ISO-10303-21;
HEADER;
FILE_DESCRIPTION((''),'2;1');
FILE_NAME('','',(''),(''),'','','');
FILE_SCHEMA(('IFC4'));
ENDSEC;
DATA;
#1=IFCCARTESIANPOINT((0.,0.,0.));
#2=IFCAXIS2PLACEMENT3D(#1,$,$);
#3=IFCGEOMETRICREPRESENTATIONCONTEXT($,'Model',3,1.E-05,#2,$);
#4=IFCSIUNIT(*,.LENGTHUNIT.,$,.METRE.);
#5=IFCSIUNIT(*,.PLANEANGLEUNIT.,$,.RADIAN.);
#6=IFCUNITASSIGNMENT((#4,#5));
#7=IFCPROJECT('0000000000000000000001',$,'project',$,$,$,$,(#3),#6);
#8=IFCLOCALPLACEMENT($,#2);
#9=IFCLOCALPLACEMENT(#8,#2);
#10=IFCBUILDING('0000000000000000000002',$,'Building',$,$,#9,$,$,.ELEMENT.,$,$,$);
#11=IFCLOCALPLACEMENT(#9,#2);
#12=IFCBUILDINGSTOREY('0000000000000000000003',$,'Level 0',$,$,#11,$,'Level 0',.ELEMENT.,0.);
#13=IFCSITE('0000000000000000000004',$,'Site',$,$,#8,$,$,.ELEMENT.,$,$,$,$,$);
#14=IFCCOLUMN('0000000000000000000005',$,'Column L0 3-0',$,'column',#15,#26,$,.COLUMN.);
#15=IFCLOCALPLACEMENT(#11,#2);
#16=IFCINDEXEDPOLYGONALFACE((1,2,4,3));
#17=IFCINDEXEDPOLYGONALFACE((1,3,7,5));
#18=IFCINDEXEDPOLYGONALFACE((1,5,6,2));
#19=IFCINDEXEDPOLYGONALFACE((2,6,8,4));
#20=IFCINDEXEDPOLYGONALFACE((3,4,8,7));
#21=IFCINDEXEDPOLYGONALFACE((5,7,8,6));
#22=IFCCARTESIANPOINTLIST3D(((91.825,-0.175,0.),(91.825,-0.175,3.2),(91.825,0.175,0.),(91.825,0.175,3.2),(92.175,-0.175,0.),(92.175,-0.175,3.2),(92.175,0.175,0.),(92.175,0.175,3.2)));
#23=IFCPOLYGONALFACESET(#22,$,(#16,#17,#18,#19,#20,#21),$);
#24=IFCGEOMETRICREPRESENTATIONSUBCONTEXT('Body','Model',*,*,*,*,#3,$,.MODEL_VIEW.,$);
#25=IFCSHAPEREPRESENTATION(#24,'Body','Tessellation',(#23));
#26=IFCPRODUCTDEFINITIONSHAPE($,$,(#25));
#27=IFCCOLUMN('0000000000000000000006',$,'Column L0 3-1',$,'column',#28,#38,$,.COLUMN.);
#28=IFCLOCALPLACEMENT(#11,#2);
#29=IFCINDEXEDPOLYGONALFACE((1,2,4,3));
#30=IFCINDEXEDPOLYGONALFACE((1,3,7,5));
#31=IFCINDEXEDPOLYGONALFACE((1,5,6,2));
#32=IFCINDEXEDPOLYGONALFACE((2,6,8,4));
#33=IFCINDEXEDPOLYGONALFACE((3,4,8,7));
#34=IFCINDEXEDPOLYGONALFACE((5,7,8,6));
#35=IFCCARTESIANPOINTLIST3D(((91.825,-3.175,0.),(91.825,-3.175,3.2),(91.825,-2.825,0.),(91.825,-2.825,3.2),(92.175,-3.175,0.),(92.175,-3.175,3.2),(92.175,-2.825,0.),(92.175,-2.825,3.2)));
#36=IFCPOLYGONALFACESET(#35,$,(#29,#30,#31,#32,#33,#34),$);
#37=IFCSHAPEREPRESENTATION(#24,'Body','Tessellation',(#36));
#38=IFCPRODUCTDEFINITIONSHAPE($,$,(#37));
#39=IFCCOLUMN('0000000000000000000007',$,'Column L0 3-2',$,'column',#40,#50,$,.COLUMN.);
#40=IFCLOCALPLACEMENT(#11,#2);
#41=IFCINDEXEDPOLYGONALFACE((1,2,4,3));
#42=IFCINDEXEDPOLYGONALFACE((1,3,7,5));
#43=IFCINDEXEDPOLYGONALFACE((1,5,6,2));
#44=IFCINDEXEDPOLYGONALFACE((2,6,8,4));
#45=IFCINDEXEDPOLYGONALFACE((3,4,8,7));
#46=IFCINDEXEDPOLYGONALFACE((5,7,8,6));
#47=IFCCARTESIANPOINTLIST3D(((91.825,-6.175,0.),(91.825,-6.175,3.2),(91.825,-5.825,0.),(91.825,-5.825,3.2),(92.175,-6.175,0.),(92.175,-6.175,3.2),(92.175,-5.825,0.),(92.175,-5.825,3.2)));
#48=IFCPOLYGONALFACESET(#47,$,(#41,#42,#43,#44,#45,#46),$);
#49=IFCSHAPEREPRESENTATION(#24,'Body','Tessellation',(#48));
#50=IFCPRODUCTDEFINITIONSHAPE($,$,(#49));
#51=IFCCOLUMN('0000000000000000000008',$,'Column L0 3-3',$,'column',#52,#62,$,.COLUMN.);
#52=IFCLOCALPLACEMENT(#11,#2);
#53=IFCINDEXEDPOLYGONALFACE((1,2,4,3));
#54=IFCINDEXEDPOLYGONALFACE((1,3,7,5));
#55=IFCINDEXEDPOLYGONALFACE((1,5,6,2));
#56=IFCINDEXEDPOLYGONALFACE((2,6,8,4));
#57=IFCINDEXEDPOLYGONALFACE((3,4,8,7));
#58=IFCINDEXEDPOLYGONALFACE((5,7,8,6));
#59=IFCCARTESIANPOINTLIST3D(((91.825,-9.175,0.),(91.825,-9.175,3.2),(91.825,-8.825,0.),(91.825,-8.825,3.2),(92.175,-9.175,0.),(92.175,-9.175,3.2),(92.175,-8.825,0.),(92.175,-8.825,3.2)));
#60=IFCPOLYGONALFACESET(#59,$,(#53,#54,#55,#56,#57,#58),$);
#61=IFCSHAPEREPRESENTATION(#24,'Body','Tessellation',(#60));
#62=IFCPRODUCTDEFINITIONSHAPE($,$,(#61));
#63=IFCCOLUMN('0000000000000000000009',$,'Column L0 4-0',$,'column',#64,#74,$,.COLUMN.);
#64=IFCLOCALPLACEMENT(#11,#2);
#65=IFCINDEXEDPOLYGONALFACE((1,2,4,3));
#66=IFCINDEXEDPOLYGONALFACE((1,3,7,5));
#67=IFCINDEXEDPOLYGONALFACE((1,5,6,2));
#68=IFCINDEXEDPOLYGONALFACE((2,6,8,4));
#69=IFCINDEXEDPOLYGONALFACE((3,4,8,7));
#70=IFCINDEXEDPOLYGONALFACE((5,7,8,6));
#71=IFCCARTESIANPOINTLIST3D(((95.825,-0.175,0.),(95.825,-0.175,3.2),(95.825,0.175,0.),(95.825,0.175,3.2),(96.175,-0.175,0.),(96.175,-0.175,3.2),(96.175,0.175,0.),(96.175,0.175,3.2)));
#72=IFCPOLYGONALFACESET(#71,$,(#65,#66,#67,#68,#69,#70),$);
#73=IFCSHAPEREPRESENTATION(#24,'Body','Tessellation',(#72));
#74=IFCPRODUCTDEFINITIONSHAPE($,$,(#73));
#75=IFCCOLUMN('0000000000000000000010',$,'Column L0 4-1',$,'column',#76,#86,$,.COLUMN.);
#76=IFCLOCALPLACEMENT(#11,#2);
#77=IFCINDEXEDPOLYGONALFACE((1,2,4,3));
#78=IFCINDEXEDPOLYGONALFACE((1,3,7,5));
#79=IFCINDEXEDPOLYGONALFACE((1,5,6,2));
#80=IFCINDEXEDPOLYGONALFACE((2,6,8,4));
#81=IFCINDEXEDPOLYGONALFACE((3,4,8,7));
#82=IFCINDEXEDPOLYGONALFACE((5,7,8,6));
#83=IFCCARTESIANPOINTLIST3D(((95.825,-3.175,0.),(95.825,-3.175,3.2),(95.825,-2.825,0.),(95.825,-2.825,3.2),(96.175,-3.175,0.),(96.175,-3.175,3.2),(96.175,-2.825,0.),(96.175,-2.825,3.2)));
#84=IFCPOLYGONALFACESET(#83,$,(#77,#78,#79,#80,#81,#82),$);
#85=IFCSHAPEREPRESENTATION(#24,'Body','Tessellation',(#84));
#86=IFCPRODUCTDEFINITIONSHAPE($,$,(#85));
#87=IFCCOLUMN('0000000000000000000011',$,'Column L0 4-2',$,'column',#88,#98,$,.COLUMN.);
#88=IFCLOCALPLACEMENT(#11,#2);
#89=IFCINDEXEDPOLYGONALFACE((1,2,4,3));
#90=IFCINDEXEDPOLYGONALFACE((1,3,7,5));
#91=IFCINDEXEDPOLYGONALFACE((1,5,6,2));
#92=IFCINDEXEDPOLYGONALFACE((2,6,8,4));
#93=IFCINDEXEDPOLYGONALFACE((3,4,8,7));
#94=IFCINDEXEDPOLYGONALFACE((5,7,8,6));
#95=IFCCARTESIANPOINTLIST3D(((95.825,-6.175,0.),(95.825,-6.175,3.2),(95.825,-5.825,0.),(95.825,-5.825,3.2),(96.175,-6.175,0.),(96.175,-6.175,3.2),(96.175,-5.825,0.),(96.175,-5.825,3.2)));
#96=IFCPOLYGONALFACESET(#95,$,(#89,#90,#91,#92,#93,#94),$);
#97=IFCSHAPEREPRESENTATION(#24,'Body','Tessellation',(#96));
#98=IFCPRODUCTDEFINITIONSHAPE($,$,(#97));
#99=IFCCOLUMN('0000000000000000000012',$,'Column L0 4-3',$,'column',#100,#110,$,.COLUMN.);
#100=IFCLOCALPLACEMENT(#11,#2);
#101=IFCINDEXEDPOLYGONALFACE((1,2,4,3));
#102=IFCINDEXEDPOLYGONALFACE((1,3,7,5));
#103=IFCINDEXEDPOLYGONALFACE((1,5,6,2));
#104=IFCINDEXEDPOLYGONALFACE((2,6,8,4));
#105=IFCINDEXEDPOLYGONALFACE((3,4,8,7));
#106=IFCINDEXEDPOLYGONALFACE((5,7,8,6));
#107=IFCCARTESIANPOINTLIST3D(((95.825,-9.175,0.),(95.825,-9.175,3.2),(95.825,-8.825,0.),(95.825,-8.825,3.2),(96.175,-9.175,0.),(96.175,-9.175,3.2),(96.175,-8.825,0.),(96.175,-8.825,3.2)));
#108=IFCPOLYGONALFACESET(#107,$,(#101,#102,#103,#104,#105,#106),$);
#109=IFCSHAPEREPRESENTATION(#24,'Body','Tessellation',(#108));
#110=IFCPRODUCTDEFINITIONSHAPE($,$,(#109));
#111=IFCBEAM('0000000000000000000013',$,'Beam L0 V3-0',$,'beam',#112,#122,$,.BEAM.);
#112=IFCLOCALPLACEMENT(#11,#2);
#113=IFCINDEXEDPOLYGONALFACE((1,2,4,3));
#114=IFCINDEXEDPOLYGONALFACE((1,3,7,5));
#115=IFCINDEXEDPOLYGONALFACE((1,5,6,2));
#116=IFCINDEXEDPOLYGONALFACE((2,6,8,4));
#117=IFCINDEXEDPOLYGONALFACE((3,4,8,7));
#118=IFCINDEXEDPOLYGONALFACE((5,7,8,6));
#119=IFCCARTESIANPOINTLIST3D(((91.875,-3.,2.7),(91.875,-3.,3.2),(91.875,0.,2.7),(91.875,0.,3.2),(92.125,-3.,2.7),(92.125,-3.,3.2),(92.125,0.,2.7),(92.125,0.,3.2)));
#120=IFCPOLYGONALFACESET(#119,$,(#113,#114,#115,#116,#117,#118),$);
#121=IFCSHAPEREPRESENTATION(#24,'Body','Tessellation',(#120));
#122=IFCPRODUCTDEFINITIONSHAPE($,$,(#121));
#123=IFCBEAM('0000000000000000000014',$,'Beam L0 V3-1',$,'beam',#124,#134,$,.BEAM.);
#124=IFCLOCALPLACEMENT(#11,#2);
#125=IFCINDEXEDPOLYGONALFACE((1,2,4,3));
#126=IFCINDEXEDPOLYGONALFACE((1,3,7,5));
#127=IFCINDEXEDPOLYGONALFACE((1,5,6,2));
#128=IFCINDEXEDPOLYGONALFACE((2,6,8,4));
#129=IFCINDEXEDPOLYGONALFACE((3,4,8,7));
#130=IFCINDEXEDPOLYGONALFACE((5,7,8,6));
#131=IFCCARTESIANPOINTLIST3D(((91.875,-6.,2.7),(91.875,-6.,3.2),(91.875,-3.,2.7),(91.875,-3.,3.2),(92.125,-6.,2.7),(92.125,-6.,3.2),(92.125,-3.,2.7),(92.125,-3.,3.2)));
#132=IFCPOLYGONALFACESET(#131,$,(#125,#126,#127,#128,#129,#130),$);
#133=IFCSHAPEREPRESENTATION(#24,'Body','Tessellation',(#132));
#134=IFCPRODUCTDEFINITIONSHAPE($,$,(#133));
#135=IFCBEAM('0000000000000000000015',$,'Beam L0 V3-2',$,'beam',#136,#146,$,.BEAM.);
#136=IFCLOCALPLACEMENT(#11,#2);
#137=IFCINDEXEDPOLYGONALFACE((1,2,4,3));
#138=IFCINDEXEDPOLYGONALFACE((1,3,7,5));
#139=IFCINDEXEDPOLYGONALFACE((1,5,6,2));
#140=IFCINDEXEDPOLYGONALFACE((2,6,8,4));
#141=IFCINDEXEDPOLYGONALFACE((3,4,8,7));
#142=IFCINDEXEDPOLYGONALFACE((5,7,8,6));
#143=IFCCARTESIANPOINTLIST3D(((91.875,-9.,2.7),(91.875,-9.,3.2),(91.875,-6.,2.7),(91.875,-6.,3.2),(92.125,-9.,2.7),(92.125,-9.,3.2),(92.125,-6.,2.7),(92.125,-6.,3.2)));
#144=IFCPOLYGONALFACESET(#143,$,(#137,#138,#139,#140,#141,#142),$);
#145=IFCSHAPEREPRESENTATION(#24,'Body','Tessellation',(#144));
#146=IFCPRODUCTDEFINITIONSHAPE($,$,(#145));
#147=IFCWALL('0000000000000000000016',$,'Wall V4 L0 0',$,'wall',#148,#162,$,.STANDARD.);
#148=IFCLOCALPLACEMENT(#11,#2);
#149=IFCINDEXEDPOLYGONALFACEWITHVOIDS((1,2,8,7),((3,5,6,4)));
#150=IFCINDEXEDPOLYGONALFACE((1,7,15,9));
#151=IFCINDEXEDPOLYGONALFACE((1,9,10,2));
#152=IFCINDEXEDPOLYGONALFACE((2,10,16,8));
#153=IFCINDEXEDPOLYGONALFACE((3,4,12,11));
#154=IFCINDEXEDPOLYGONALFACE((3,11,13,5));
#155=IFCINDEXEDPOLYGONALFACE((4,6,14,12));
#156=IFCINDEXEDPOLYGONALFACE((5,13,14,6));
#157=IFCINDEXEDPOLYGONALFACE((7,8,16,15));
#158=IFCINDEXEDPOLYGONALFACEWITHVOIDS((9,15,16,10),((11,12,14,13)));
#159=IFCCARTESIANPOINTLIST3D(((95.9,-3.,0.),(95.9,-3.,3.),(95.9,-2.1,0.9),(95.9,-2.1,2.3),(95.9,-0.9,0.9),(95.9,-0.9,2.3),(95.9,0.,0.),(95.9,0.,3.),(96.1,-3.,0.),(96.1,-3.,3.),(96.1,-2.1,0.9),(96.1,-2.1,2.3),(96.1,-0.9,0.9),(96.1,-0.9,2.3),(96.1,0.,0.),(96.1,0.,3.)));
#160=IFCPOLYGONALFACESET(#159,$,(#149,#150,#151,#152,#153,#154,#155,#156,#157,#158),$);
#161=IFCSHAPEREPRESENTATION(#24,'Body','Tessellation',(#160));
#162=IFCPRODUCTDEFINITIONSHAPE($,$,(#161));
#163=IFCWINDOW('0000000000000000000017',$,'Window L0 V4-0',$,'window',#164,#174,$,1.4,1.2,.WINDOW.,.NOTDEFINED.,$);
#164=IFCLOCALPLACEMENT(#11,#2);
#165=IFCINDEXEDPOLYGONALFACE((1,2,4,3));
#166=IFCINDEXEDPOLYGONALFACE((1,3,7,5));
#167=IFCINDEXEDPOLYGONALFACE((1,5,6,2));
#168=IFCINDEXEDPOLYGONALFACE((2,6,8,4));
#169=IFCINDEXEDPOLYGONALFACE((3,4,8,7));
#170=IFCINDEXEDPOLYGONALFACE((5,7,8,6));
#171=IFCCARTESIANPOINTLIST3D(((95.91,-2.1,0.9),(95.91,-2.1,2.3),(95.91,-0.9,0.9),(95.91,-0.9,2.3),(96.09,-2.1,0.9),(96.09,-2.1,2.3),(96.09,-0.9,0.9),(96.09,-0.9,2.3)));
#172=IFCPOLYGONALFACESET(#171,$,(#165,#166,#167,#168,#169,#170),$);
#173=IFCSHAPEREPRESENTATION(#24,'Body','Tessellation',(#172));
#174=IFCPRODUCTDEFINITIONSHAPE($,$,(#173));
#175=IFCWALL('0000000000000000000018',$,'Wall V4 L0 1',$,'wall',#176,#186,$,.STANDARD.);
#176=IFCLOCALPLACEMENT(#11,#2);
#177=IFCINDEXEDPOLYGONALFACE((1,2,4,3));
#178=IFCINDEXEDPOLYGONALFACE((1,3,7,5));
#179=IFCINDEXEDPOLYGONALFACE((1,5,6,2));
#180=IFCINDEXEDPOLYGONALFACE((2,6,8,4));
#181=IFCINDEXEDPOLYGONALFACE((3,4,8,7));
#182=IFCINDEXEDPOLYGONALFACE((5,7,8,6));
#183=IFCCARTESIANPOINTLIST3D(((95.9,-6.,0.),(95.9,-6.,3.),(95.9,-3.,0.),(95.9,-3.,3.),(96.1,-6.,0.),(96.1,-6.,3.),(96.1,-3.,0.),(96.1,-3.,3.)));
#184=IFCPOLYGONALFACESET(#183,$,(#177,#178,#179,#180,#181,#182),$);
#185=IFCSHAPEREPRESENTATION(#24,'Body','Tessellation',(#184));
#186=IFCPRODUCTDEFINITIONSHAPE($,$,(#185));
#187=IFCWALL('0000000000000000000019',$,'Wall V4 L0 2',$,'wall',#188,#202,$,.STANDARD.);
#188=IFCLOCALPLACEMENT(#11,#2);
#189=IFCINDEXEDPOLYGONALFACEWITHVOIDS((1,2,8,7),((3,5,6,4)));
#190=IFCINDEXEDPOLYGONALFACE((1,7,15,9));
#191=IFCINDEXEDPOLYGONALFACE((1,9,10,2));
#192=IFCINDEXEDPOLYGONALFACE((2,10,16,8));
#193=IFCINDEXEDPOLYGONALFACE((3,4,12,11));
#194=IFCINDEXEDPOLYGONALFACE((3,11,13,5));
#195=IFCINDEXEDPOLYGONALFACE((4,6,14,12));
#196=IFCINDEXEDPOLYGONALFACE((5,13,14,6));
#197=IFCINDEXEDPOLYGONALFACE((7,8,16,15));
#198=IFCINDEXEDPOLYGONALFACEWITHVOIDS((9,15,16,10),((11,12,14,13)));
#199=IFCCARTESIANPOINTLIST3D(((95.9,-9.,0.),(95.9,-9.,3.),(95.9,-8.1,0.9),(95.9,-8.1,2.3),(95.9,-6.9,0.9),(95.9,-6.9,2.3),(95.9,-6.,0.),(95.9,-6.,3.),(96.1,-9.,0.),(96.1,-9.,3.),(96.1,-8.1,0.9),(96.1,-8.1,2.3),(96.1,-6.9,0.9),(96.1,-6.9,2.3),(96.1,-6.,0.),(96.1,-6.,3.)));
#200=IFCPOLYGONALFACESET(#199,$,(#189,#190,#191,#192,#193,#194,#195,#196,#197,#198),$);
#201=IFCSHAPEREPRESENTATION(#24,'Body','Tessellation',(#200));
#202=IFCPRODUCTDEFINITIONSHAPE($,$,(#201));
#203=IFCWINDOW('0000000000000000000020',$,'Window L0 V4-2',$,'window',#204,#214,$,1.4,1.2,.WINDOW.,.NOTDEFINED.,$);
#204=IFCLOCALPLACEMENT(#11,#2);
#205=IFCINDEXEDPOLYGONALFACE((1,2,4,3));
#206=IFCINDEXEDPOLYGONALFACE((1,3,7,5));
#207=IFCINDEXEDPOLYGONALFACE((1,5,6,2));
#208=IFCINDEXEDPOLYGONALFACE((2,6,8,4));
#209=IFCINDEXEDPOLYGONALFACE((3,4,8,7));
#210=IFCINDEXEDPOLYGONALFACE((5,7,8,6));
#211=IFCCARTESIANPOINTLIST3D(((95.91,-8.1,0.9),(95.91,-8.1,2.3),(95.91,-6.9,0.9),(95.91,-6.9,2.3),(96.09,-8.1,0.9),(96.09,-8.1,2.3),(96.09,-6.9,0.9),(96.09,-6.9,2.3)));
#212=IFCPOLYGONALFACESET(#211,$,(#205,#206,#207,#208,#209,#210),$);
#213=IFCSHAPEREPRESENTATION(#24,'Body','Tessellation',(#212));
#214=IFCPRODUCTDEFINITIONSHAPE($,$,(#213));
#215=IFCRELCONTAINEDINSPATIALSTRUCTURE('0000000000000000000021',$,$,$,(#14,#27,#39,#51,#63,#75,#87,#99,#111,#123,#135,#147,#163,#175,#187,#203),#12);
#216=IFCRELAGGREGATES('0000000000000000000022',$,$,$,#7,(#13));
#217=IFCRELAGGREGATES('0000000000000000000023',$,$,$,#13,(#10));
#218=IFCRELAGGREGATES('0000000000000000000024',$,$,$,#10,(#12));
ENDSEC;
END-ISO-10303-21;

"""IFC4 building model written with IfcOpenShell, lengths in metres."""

from ifc_helpers import new_model, si_unit, frame, frame_2d, origin, origin_2d, place, context, subcontext, project, spatial, rectangle, extrude, element, fill, save


model = new_model("IFC4")

# Units and contexts
model_context = context("Model", 3, precision=1e-05, world=origin())
body_context = subcontext(model_context, "Body", "Model", "MODEL_VIEW")
ifc_project = project(units=[si_unit("LENGTHUNIT", "METRE"), si_unit("PLANEANGLEUNIT", "RADIAN")], contexts=[model_context])

# Site, building, storey
site_placement = place(None, origin())
site = spatial("IfcSite", under=ifc_project, at=site_placement, Name="Site", CompositionType="ELEMENT")
building_placement = place(site_placement, origin())
building = spatial("IfcBuilding", under=site, at=building_placement, Name="Building", CompositionType="ELEMENT")
storey_placement = place(building_placement, origin())
storey = spatial("IfcBuildingStorey", under=building, at=storey_placement, Name="Level 0", LongName="Level 0", CompositionType="ELEMENT", Elevation=0.0)

# Columns
for number, where, name in (
    (1, (92.0, 0.0, 0.0), "Column L0 3-0"),
    (2, (92.0, -3.0, 0.0), "Column L0 3-1"),
    (3, (92.0, -6.0, 0.0), "Column L0 3-2"),
    (4, (92.0, -9.0, 0.0), "Column L0 3-3"),
    (5, (96.0, 0.0, 0.0), "Column L0 4-0"),
    (6, (96.0, -3.0, 0.0), "Column L0 4-1"),
    (7, (96.0, -6.0, 0.0), "Column L0 4-2"),
    (8, (96.0, -9.0, 0.0), "Column L0 4-3"),
):
    element("IfcColumn", number, at=place(storey_placement, frame(where)), inside=storey, Name=name, ObjectType="column", PredefinedType="COLUMN", context=body_context, shape_type="SweptSolid", body=[
        extrude(rectangle(XDim=0.35, YDim=0.35, at=origin_2d()), origin(), (0.0, 0.0, 1.0), 3.2),
    ])

# Beams
for number, where, z_axis, x_axis, name in (
    (9, (92.0, 0.0, 2.95), (0.0, -1.0, 0.0), (0.0, 0.0, 1.0), "Beam L0 V3-0"),
    (10, (92.0, -3.0, 2.95), (0.0, -1.0, 0.0), (0.0, 0.0, 1.0), "Beam L0 V3-1"),
    (11, (92.0, -6.0, 2.95), (0.0, -1.0, 0.0), (0.0, 0.0, 1.0), "Beam L0 V3-2"),
):
    element("IfcBeam", number, at=place(storey_placement, frame(where, z_axis=z_axis, x_axis=x_axis)), inside=storey, Name=name, ObjectType="beam", PredefinedType="BEAM", context=body_context, shape_type="SweptSolid", body=[
        extrude(rectangle(XDim=0.5, YDim=0.25, at=origin_2d()), origin(), (0.0, 0.0, 1.0), 3.0),
    ])

# Wall, opening, window
wall_1_placement = place(storey_placement, frame((96.0, 0.0, 0.0), z_axis=(0.0, 0.0, 1.0), x_axis=(0.0, -1.0, 0.0)))
wall_1 = element("IfcWall", 12, at=wall_1_placement, inside=storey, Name="Wall V4 L0 0", ObjectType="wall", PredefinedType="STANDARD", context=body_context, shape_type="SweptSolid", body=[
    extrude(rectangle(XDim=3.0, YDim=0.2, at=frame_2d((1.5, 0.0))), origin(), (0.0, 0.0, 1.0), 3.0),
])
opening_1_placement = place(storey_placement, frame((96.0, -1.5, 0.9), z_axis=(0.0, 0.0, 1.0), x_axis=(0.0, -1.0, 0.0)))
opening_1 = element("IfcOpeningElement", 13, at=opening_1_placement, cuts=wall_1, ObjectType="Opening", PredefinedType="OPENING", context=body_context, shape_type="SweptSolid", body=[
    extrude(rectangle(XDim=1.2, YDim=0.22, at=origin_2d()), origin(), (0.0, 0.0, 1.0), 1.4),
])
window_1_placement = place(storey_placement, frame((96.0, -1.5, 0.9), z_axis=(0.0, 0.0, 1.0), x_axis=(0.0, -1.0, 0.0)))
window_1 = element("IfcWindow", 14, at=window_1_placement, inside=storey, Name="Window L0 V4-0", ObjectType="window", OverallHeight=1.4, OverallWidth=1.2, PartitioningType="NOTDEFINED", PredefinedType="WINDOW", context=body_context, shape_type="SweptSolid", body=[
    extrude(rectangle(XDim=1.2, YDim=0.18, at=origin_2d()), origin(), (0.0, 0.0, 1.0), 1.4),
])
fill(opening_1, window_1)

# Wall
wall_2_placement = place(storey_placement, frame((96.0, -3.0, 0.0), z_axis=(0.0, 0.0, 1.0), x_axis=(0.0, -1.0, 0.0)))
element("IfcWall", 15, at=wall_2_placement, inside=storey, Name="Wall V4 L0 1", ObjectType="wall", PredefinedType="STANDARD", context=body_context, shape_type="SweptSolid", body=[
    extrude(rectangle(XDim=3.0, YDim=0.2, at=frame_2d((1.5, 0.0))), origin(), (0.0, 0.0, 1.0), 3.0),
])

# Wall, opening, window
wall_3_placement = place(storey_placement, frame((96.0, -6.0, 0.0), z_axis=(0.0, 0.0, 1.0), x_axis=(0.0, -1.0, 0.0)))
wall_3 = element("IfcWall", 16, at=wall_3_placement, inside=storey, Name="Wall V4 L0 2", ObjectType="wall", PredefinedType="STANDARD", context=body_context, shape_type="SweptSolid", body=[
    extrude(rectangle(XDim=3.0, YDim=0.2, at=frame_2d((1.5, 0.0))), origin(), (0.0, 0.0, 1.0), 3.0),
])
opening_2_placement = place(storey_placement, frame((96.0, -7.5, 0.9), z_axis=(0.0, 0.0, 1.0), x_axis=(0.0, -1.0, 0.0)))
opening_2 = element("IfcOpeningElement", 17, at=opening_2_placement, cuts=wall_3, ObjectType="Opening", PredefinedType="OPENING", context=body_context, shape_type="SweptSolid", body=[
    extrude(rectangle(XDim=1.2, YDim=0.22, at=origin_2d()), origin(), (0.0, 0.0, 1.0), 1.4),
])
window_2_placement = place(storey_placement, frame((96.0, -7.5, 0.9), z_axis=(0.0, 0.0, 1.0), x_axis=(0.0, -1.0, 0.0)))
window_2 = element("IfcWindow", 18, at=window_2_placement, inside=storey, Name="Window L0 V4-2", ObjectType="window", OverallHeight=1.4, OverallWidth=1.2, PartitioningType="NOTDEFINED", PredefinedType="WINDOW", context=body_context, shape_type="SweptSolid", body=[
    extrude(rectangle(XDim=1.2, YDim=0.18, at=origin_2d()), origin(), (0.0, 0.0, 1.0), 1.4),
])
fill(opening_2, window_2)

save(model, "model.ifc")
